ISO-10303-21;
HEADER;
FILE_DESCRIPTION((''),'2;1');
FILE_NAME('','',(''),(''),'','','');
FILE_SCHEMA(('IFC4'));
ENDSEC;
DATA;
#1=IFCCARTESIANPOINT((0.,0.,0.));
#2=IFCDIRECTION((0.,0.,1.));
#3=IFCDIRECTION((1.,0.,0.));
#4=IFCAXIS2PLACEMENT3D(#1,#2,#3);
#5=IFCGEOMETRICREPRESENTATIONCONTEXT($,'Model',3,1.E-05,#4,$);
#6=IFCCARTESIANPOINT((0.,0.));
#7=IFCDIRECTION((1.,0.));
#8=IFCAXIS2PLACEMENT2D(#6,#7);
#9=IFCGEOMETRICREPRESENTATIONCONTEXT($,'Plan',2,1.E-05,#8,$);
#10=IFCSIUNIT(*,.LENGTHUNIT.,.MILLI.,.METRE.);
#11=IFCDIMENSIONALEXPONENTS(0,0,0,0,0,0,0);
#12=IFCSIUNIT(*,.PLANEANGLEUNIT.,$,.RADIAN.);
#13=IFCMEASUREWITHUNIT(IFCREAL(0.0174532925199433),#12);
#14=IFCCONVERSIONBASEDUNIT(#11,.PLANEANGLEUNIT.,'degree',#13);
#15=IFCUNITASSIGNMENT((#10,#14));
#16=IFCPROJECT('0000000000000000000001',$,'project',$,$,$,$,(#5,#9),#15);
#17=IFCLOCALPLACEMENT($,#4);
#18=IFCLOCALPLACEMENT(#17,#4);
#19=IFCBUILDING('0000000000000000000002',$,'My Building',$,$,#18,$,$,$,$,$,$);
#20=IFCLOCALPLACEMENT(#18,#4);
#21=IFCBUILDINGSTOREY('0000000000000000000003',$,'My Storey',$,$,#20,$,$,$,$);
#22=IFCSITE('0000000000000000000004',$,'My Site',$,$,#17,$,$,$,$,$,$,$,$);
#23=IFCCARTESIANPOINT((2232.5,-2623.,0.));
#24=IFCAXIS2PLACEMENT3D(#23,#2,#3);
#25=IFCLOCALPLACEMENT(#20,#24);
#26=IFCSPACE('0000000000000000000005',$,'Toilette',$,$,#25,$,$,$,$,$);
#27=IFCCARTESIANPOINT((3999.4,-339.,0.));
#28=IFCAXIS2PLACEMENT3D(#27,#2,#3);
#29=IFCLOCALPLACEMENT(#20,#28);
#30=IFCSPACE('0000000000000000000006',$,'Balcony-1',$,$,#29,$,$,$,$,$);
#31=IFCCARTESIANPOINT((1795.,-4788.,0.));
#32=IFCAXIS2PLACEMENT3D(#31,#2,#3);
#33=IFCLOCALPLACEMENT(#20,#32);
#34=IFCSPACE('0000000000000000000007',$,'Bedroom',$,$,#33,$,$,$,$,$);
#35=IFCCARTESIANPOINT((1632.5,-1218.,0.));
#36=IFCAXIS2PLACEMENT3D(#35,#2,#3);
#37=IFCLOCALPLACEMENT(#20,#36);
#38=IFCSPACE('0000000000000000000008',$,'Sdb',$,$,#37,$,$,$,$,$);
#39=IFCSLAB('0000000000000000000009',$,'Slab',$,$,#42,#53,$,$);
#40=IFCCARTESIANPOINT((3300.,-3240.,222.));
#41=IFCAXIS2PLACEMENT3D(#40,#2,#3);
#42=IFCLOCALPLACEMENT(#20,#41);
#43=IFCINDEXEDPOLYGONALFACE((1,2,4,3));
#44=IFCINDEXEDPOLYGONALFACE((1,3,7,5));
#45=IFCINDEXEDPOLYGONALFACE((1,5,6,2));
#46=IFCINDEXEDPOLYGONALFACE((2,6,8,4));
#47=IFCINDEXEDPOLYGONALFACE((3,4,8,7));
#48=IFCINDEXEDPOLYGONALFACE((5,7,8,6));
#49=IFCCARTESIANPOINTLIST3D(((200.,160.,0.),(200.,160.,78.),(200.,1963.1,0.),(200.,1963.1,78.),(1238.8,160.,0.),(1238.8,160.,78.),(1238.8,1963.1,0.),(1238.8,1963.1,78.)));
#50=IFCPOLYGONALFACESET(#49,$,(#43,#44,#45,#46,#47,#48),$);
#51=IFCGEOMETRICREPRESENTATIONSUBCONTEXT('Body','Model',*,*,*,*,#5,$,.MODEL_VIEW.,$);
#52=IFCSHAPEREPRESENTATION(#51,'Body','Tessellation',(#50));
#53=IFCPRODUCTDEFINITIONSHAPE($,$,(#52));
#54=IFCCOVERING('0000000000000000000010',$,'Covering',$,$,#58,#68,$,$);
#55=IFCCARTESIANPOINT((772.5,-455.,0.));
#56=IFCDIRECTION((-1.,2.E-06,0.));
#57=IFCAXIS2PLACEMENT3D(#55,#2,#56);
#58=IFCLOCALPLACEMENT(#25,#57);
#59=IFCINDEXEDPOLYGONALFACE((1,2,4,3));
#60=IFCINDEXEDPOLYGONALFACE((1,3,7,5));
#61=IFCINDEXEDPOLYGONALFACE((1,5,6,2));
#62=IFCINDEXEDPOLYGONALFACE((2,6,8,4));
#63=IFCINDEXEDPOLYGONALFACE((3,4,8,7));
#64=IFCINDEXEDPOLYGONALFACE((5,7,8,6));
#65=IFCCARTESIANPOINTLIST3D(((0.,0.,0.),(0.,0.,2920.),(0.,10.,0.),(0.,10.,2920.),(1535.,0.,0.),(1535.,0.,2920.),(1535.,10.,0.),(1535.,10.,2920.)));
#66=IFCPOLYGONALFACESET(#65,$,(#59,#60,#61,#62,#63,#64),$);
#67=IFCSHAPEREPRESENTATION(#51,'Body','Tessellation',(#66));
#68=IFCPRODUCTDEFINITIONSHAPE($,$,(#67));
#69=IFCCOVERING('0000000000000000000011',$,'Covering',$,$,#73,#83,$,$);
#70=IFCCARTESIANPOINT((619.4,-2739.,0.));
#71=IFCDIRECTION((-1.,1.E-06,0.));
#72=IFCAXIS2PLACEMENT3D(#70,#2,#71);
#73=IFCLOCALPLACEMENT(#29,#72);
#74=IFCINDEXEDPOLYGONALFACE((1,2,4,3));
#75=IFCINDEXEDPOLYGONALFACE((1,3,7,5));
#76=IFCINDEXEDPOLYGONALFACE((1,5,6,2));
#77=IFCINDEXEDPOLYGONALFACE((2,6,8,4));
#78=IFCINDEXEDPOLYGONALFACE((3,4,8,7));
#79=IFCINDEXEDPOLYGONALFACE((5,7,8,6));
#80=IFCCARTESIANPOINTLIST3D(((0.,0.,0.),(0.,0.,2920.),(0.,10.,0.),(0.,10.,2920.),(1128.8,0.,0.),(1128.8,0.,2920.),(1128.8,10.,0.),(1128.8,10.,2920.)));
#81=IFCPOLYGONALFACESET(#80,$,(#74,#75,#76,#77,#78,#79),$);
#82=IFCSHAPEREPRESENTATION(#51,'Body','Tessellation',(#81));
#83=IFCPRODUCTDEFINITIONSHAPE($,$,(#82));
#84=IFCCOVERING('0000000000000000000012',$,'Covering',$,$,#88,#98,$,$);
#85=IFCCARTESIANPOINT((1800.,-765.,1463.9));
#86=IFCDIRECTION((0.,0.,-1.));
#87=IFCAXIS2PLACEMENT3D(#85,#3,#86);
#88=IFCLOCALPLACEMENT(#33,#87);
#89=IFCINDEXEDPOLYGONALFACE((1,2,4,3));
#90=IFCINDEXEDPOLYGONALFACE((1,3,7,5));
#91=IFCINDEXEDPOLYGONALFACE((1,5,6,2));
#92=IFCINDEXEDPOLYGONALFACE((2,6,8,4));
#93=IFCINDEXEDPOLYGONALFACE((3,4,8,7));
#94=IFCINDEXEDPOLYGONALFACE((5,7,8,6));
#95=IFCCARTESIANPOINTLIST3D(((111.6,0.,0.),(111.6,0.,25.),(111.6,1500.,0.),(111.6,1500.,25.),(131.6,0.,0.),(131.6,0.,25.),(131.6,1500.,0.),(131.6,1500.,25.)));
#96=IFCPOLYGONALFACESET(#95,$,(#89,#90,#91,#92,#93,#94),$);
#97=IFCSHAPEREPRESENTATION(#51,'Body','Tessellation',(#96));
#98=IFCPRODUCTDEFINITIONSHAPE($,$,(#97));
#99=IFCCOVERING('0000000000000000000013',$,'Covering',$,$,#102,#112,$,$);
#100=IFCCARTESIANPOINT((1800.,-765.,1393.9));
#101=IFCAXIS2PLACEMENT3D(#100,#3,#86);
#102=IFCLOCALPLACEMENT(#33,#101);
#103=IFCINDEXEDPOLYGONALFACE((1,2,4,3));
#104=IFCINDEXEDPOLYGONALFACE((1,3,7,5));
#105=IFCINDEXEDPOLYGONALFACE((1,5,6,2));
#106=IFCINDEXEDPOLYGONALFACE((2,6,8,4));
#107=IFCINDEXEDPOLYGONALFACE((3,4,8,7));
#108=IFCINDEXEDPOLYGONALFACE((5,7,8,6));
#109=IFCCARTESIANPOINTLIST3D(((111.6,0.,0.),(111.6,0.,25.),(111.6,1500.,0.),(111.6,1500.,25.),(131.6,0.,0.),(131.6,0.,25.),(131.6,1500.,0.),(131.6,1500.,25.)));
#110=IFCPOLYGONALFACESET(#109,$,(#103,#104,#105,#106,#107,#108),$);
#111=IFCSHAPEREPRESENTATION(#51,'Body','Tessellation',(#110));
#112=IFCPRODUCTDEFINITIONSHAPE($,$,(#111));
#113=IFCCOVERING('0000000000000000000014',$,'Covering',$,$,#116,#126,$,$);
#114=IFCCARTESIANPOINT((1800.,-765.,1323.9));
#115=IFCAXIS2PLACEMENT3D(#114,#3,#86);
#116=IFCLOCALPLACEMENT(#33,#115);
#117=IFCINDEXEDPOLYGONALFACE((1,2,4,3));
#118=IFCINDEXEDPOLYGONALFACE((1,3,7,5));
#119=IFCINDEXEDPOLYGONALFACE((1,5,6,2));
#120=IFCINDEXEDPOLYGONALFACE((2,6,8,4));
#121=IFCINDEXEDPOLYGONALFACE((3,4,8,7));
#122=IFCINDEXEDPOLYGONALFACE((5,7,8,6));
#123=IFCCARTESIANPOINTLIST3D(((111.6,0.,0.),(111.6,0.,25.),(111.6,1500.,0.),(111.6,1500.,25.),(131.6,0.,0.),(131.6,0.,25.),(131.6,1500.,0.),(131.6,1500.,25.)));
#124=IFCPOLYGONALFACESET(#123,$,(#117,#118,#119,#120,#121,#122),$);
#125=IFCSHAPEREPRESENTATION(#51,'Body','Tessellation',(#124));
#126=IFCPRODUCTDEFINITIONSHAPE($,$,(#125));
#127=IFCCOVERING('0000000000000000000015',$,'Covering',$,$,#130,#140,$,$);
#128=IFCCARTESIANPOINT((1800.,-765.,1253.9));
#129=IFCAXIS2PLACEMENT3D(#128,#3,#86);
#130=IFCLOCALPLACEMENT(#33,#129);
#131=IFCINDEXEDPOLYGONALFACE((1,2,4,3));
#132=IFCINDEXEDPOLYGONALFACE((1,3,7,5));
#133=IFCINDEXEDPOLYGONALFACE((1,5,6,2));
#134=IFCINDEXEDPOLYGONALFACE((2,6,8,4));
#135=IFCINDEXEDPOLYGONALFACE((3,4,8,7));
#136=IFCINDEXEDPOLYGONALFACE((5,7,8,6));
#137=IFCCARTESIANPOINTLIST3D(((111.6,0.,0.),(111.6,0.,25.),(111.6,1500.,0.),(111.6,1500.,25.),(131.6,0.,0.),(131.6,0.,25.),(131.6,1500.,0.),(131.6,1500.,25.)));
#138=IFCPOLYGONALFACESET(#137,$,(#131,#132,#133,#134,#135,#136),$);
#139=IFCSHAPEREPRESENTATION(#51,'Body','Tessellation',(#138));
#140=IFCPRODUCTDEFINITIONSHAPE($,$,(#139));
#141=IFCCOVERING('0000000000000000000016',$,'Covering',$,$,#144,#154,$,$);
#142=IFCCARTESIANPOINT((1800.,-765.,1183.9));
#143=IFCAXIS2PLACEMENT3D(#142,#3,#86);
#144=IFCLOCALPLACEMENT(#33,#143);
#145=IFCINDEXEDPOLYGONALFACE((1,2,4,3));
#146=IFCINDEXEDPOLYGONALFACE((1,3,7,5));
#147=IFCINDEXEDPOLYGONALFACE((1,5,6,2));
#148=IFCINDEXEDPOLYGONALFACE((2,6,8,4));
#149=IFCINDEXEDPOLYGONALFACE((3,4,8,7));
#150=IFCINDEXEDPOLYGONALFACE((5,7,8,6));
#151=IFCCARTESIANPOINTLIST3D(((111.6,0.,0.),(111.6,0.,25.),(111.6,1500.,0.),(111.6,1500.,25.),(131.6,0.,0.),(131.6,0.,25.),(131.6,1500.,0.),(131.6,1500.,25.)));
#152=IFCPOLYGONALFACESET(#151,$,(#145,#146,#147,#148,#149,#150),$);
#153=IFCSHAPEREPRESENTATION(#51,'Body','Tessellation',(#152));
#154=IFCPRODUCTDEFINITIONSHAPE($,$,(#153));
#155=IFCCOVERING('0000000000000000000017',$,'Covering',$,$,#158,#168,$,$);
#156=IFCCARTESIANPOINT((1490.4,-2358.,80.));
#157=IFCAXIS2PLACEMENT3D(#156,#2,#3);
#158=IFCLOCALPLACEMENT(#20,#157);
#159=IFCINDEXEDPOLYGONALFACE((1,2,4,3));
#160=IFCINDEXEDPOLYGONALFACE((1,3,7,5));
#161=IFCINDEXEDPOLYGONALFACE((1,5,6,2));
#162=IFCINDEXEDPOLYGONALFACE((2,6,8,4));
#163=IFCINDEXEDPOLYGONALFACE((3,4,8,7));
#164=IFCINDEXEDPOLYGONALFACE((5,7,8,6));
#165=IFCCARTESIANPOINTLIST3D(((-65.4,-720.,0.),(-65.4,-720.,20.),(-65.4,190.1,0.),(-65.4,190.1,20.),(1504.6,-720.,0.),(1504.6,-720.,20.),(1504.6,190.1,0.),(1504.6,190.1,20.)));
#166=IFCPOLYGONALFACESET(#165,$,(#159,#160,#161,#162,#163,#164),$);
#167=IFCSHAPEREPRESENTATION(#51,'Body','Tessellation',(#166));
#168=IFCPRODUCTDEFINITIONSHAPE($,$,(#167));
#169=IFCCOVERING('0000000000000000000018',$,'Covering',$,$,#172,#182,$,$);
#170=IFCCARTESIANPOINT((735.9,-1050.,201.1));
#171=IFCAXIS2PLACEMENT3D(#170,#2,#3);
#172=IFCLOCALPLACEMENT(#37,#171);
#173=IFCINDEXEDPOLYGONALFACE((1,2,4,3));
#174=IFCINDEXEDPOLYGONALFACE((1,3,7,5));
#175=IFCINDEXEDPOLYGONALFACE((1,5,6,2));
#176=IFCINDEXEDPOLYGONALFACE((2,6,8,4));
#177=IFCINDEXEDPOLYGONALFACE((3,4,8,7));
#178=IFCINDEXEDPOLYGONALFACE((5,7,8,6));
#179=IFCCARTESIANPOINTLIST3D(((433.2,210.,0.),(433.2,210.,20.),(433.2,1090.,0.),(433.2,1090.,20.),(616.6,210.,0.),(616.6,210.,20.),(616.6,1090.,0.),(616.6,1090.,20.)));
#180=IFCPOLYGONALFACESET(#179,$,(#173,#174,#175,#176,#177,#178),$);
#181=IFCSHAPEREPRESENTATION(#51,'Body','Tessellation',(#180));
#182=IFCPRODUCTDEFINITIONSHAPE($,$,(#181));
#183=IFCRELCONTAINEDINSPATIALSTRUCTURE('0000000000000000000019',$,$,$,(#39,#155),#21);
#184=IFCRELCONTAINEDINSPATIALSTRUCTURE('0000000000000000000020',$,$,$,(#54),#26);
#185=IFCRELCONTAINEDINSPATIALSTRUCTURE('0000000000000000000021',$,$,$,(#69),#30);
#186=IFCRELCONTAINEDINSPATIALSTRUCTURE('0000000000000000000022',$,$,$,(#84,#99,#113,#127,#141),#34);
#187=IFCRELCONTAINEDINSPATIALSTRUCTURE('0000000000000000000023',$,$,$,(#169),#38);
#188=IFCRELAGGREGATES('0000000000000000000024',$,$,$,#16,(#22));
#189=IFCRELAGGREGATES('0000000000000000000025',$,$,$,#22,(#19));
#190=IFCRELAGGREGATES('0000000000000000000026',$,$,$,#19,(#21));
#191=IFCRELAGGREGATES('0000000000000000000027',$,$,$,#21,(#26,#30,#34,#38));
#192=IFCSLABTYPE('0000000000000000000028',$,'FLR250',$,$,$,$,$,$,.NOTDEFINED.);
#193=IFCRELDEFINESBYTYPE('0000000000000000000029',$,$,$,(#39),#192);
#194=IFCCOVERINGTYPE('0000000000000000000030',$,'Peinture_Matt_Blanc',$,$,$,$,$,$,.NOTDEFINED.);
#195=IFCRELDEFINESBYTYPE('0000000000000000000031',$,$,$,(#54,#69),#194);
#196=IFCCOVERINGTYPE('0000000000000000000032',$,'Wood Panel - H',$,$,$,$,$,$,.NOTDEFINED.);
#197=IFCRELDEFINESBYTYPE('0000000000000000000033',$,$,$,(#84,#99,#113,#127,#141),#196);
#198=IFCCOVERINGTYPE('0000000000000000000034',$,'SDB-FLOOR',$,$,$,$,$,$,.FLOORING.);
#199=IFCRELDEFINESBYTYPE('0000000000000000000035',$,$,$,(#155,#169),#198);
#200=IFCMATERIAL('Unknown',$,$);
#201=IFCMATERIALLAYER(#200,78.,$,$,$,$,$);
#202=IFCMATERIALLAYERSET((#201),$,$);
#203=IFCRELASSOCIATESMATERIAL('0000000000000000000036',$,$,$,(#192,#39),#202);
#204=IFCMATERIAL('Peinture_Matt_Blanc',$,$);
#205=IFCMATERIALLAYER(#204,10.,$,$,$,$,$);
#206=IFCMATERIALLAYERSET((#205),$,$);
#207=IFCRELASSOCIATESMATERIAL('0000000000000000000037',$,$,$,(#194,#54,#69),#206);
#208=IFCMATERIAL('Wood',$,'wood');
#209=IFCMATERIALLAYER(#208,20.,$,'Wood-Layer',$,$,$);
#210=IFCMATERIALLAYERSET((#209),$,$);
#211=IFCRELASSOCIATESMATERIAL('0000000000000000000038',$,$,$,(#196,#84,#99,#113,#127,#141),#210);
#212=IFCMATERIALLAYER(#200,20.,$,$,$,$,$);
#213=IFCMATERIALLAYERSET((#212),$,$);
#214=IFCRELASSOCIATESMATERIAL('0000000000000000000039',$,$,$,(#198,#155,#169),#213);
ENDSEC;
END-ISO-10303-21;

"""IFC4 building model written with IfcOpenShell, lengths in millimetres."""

from ifc_helpers import new_model, entity, si_unit, converted_unit, frame, origin_with_axes, origin_2d_with_axis, place, context, subcontext, project, spatial, line, indexed_curve, outline, extrude, clip, halfspace, material, layer, layer_set, layer_usage, type_object, element, save


model = new_model("IFC4")

# Units and contexts
model_context = context("Model", 3, precision=1e-05, world=origin_with_axes())
plan_context = context("Plan", 2, precision=1e-05, world=origin_2d_with_axis())
body_context_1 = subcontext(model_context, "Body", "Model", "MODEL_VIEW")
ifc_project = project(units=[si_unit("LENGTHUNIT", "METRE", prefix="MILLI"), converted_unit("PLANEANGLEUNIT", "degree", entity("IfcReal", 0.0174532925199433), si_unit("PLANEANGLEUNIT", "RADIAN"), dimensions=[0, 0, 0, 0, 0, 0, 0])], contexts=[model_context, plan_context])

# Site, building, storey
site_placement = place(None, origin_with_axes())
site = spatial("IfcSite", under=ifc_project, at=site_placement, Name="My Site")
building_placement = place(site_placement, origin_with_axes())
building = spatial("IfcBuilding", under=site, at=building_placement, Name="My Building")
storey_placement = place(building_placement, origin_with_axes())
storey = spatial("IfcBuildingStorey", under=building, at=storey_placement, Name="My Storey")

# Slab
ifc_material_1 = material(Name="Unknown")
ifc_layer_1 = layer(ifc_material_1, 78.0)
ifc_layer_set_1 = layer_set([ifc_layer_1])
ifc_layer_usage_1 = layer_usage(ifc_layer_set_1, "AXIS3", "POSITIVE", 0.0)
slab_type = type_object("IfcSlabType", Name="FLR250", PredefinedType="NOTDEFINED", material=ifc_layer_set_1)
slab_placement = place(storey_placement, frame((3300.0, -3240.0, 222.0), z_axis=(0.0, 0.0, 1.0), x_axis=(1.0, 0.0, 0.0)))
element("IfcSlab", 1, at=slab_placement, inside=storey, type_object=slab_type, material=ifc_layer_usage_1, Name="Slab", context=body_context_1, shape_type="SweptSolid", body=[
    extrude(outline(indexed_curve([(200.0, 160.0), (1238.8, 160.0), (1238.8, 1963.1), (200.0, 1963.1)], segments=[line(4, 1), line(1, 2), line(2, 3), line(3, 4)], self_intersect=False)), None, (0.0, 0.0, 1.0), 78.0),
])

# Shared definitions
space_1_placement = place(storey_placement, frame((2232.5, -2623.0, 0.0), z_axis=(0.0, 0.0, 1.0), x_axis=(1.0, 0.0, 0.0)))
space_1 = spatial("IfcSpace", under=storey, at=space_1_placement, Name="Toilette")

# Shared definitions
ifc_material_2 = material(Name="Peinture_Matt_Blanc")
ifc_layer_2 = layer(ifc_material_2, 10.0)
ifc_layer_set_2 = layer_set([ifc_layer_2])
covering_type_1 = type_object("IfcCoveringType", Name="Peinture_Matt_Blanc", PredefinedType="NOTDEFINED", material=ifc_layer_set_2)

# Covering
ifc_layer_usage_2 = layer_usage(ifc_layer_set_2, "AXIS2", "POSITIVE", 0.0)
covering_1_placement = place(space_1_placement, frame((772.5, -455.0, 0.0), z_axis=(0.0, 0.0, 1.0), x_axis=(-1.0, 0.000002, 0.0)))
element("IfcCovering", 2, at=covering_1_placement, inside=space_1, type_object=covering_type_1, material=ifc_layer_usage_2, Name="Covering", context=body_context_1, shape_type="Clipping", body=[
    clip(clip(extrude(outline(indexed_curve([(0.0, 0.0), (0.0, 10.0), (1535.0, 10.0), (1535.0, 0.0), (0.0, 0.0)], self_intersect=False)), origin_with_axes(), (0.0, 0.0, 1.0), 2920.0), halfspace(frame((0.0, 0.0, 2920.0), z_axis=(0.0, 0.0, 1.0), x_axis=(-1.0, 0.0, 0.0)), False)), halfspace(frame((0.0, 0.0, 2920.0), z_axis=(0.0, 0.0, 1.0), x_axis=(-1.0, 0.0, 0.0)), False)),
])

# Shared definitions
space_2_placement = place(storey_placement, frame((3999.4, -339.0, 0.0), z_axis=(0.0, 0.0, 1.0), x_axis=(1.0, 0.0, 0.0)))
space_2 = spatial("IfcSpace", under=storey, at=space_2_placement, Name="Balcony-1")

# Covering
ifc_layer_usage_3 = layer_usage(ifc_layer_set_2, "AXIS2", "POSITIVE", 0.0)
covering_2_placement = place(space_2_placement, frame((619.4, -2739.0, 0.0), z_axis=(0.0, 0.0, 1.0), x_axis=(-1.0, 0.000001, 0.0)))
element("IfcCovering", 3, at=covering_2_placement, inside=space_2, type_object=covering_type_1, material=ifc_layer_usage_3, Name="Covering", context=body_context_1, shape_type="Clipping", body=[
    clip(clip(extrude(outline(indexed_curve([(0.0, 0.0), (0.0, 10.0), (1128.8, 10.0), (1128.8, 0.0), (0.0, 0.0)], self_intersect=False)), origin_with_axes(), (0.0, 0.0, 1.0), 2920.0), halfspace(frame((0.0, 0.0, 2920.0), z_axis=(0.0, 0.0, 1.0), x_axis=(-1.0, 0.0, 0.0)), False)), halfspace(frame((0.0, 0.0, 2920.0), z_axis=(0.0, 0.0, 1.0), x_axis=(-1.0, 0.0, 0.0)), False)),
])

# Shared definitions
space_3_placement = place(storey_placement, frame((1795.0, -4788.0, 0.0), z_axis=(0.0, 0.0, 1.0), x_axis=(1.0, 0.0, 0.0)))
space_3 = spatial("IfcSpace", under=storey, at=space_3_placement, Name="Bedroom")

# Coverings
ifc_material_3 = material(Name="Wood", Category="wood")
ifc_layer_3 = layer(ifc_material_3, 20.0, Name="Wood-Layer")
ifc_layer_set_3 = layer_set([ifc_layer_3])
ifc_layer_usage_4 = layer_usage(ifc_layer_set_3, "AXIS3", "POSITIVE", 0.0)
covering_type_2 = type_object("IfcCoveringType", Name="Wood Panel - H", PredefinedType="NOTDEFINED", material=ifc_layer_set_3)
covering_3_placement = place(space_3_placement, frame((1800.0, -765.0, 1463.9), z_axis=(1.0, 0.0, 0.0), x_axis=(0.0, 0.0, -1.0)))
element("IfcCovering", 4, at=covering_3_placement, inside=space_3, type_object=covering_type_2, material=ifc_layer_usage_4, Name="Covering", context=body_context_1, shape_type="SweptSolid", body=[
    extrude(outline(indexed_curve([(131.6, 1500.0), (111.6, 1500.0), (111.6, 0.0), (131.6, 0.0)], segments=[line(3, 2), line(2, 1), line(1, 4), line(4, 3)], self_intersect=False)), None, (0.0, 0.0, 1.0), 25.0),
])
ifc_layer_usage_5 = layer_usage(ifc_layer_set_3, "AXIS3", "POSITIVE", 0.0)
covering_4_placement = place(space_3_placement, frame((1800.0, -765.0, 1393.9), z_axis=(1.0, 0.0, 0.0), x_axis=(0.0, 0.0, -1.0)))
element("IfcCovering", 5, at=covering_4_placement, inside=space_3, type_object=covering_type_2, material=ifc_layer_usage_5, Name="Covering", context=body_context_1, shape_type="SweptSolid", body=[
    extrude(outline(indexed_curve([(131.6, 1500.0), (111.6, 1500.0), (111.6, 0.0), (131.6, 0.0)], segments=[line(3, 2), line(2, 1), line(1, 4), line(4, 3)], self_intersect=False)), None, (0.0, 0.0, 1.0), 25.0),
])
ifc_layer_usage_6 = layer_usage(ifc_layer_set_3, "AXIS3", "POSITIVE", 0.0)
covering_5_placement = place(space_3_placement, frame((1800.0, -765.0, 1323.9), z_axis=(1.0, 0.0, 0.0), x_axis=(0.0, 0.0, -1.0)))
element("IfcCovering", 6, at=covering_5_placement, inside=space_3, type_object=covering_type_2, material=ifc_layer_usage_6, Name="Covering", context=body_context_1, shape_type="SweptSolid", body=[
    extrude(outline(indexed_curve([(131.6, 1500.0), (111.6, 1500.0), (111.6, 0.0), (131.6, 0.0)], segments=[line(3, 2), line(2, 1), line(1, 4), line(4, 3)], self_intersect=False)), None, (0.0, 0.0, 1.0), 25.0),
])
ifc_layer_usage_7 = layer_usage(ifc_layer_set_3, "AXIS3", "POSITIVE", 0.0)
covering_6_placement = place(space_3_placement, frame((1800.0, -765.0, 1253.9), z_axis=(1.0, 0.0, 0.0), x_axis=(0.0, 0.0, -1.0)))
element("IfcCovering", 7, at=covering_6_placement, inside=space_3, type_object=covering_type_2, material=ifc_layer_usage_7, Name="Covering", context=body_context_1, shape_type="SweptSolid", body=[
    extrude(outline(indexed_curve([(131.6, 1500.0), (111.6, 1500.0), (111.6, 0.0), (131.6, 0.0)], segments=[line(3, 2), line(2, 1), line(1, 4), line(4, 3)], self_intersect=False)), None, (0.0, 0.0, 1.0), 25.0),
])
ifc_layer_usage_8 = layer_usage(ifc_layer_set_3, "AXIS3", "POSITIVE", 0.0)
covering_7_placement = place(space_3_placement, frame((1800.0, -765.0, 1183.9), z_axis=(1.0, 0.0, 0.0), x_axis=(0.0, 0.0, -1.0)))
element("IfcCovering", 8, at=covering_7_placement, inside=space_3, type_object=covering_type_2, material=ifc_layer_usage_8, Name="Covering", context=body_context_1, shape_type="SweptSolid", body=[
    extrude(outline(indexed_curve([(131.6, 1500.0), (111.6, 1500.0), (111.6, 0.0), (131.6, 0.0)], segments=[line(3, 2), line(2, 1), line(1, 4), line(4, 3)], self_intersect=False)), None, (0.0, 0.0, 1.0), 25.0),
])
ifc_layer_4 = layer(ifc_material_1, 20.0)
ifc_layer_set_4 = layer_set([ifc_layer_4])
ifc_layer_usage_9 = layer_usage(ifc_layer_set_4, "AXIS3", "POSITIVE", 0.0)
covering_type_3 = type_object("IfcCoveringType", Name="SDB-FLOOR", PredefinedType="FLOORING", material=ifc_layer_set_4)
covering_8_placement = place(storey_placement, frame((1490.4, -2358.0, 80.0), z_axis=(0.0, 0.0, 1.0), x_axis=(1.0, 0.0, 0.0)))
element("IfcCovering", 9, at=covering_8_placement, inside=storey, type_object=covering_type_3, material=ifc_layer_usage_9, Name="Covering", context=body_context_1, shape_type="SweptSolid", body=[
    extrude(outline(indexed_curve([(-65.4, -720.0), (-65.4, 190.1), (1504.6, 190.1), (1504.6, -720.0)], segments=[line(3, 2), line(2, 1), line(1, 4), line(4, 3)], self_intersect=False)), None, (0.0, 0.0, 1.0), 20.0),
])

# Shared definitions
space_4_placement = place(storey_placement, frame((1632.5, -1218.0, 0.0), z_axis=(0.0, 0.0, 1.0), x_axis=(1.0, 0.0, 0.0)))
space_4 = spatial("IfcSpace", under=storey, at=space_4_placement, Name="Sdb")

# Covering
ifc_layer_usage_10 = layer_usage(ifc_layer_set_4, "AXIS3", "POSITIVE", 0.0)
covering_9_placement = place(space_4_placement, frame((735.9, -1050.0, 201.1), z_axis=(0.0, 0.0, 1.0), x_axis=(1.0, 0.0, 0.0)))
element("IfcCovering", 10, at=covering_9_placement, inside=space_4, type_object=covering_type_3, material=ifc_layer_usage_10, Name="Covering", context=body_context_1, shape_type="SweptSolid", body=[
    extrude(outline(indexed_curve([(616.6, 1090.0), (616.6, 210.0), (433.2, 210.0), (433.2, 1090.0)], segments=[line(4, 1), line(1, 2), line(2, 3), line(3, 4)], self_intersect=False)), None, (0.0, 0.0, 1.0), 20.0),
])

save(model, "model.ifc")
